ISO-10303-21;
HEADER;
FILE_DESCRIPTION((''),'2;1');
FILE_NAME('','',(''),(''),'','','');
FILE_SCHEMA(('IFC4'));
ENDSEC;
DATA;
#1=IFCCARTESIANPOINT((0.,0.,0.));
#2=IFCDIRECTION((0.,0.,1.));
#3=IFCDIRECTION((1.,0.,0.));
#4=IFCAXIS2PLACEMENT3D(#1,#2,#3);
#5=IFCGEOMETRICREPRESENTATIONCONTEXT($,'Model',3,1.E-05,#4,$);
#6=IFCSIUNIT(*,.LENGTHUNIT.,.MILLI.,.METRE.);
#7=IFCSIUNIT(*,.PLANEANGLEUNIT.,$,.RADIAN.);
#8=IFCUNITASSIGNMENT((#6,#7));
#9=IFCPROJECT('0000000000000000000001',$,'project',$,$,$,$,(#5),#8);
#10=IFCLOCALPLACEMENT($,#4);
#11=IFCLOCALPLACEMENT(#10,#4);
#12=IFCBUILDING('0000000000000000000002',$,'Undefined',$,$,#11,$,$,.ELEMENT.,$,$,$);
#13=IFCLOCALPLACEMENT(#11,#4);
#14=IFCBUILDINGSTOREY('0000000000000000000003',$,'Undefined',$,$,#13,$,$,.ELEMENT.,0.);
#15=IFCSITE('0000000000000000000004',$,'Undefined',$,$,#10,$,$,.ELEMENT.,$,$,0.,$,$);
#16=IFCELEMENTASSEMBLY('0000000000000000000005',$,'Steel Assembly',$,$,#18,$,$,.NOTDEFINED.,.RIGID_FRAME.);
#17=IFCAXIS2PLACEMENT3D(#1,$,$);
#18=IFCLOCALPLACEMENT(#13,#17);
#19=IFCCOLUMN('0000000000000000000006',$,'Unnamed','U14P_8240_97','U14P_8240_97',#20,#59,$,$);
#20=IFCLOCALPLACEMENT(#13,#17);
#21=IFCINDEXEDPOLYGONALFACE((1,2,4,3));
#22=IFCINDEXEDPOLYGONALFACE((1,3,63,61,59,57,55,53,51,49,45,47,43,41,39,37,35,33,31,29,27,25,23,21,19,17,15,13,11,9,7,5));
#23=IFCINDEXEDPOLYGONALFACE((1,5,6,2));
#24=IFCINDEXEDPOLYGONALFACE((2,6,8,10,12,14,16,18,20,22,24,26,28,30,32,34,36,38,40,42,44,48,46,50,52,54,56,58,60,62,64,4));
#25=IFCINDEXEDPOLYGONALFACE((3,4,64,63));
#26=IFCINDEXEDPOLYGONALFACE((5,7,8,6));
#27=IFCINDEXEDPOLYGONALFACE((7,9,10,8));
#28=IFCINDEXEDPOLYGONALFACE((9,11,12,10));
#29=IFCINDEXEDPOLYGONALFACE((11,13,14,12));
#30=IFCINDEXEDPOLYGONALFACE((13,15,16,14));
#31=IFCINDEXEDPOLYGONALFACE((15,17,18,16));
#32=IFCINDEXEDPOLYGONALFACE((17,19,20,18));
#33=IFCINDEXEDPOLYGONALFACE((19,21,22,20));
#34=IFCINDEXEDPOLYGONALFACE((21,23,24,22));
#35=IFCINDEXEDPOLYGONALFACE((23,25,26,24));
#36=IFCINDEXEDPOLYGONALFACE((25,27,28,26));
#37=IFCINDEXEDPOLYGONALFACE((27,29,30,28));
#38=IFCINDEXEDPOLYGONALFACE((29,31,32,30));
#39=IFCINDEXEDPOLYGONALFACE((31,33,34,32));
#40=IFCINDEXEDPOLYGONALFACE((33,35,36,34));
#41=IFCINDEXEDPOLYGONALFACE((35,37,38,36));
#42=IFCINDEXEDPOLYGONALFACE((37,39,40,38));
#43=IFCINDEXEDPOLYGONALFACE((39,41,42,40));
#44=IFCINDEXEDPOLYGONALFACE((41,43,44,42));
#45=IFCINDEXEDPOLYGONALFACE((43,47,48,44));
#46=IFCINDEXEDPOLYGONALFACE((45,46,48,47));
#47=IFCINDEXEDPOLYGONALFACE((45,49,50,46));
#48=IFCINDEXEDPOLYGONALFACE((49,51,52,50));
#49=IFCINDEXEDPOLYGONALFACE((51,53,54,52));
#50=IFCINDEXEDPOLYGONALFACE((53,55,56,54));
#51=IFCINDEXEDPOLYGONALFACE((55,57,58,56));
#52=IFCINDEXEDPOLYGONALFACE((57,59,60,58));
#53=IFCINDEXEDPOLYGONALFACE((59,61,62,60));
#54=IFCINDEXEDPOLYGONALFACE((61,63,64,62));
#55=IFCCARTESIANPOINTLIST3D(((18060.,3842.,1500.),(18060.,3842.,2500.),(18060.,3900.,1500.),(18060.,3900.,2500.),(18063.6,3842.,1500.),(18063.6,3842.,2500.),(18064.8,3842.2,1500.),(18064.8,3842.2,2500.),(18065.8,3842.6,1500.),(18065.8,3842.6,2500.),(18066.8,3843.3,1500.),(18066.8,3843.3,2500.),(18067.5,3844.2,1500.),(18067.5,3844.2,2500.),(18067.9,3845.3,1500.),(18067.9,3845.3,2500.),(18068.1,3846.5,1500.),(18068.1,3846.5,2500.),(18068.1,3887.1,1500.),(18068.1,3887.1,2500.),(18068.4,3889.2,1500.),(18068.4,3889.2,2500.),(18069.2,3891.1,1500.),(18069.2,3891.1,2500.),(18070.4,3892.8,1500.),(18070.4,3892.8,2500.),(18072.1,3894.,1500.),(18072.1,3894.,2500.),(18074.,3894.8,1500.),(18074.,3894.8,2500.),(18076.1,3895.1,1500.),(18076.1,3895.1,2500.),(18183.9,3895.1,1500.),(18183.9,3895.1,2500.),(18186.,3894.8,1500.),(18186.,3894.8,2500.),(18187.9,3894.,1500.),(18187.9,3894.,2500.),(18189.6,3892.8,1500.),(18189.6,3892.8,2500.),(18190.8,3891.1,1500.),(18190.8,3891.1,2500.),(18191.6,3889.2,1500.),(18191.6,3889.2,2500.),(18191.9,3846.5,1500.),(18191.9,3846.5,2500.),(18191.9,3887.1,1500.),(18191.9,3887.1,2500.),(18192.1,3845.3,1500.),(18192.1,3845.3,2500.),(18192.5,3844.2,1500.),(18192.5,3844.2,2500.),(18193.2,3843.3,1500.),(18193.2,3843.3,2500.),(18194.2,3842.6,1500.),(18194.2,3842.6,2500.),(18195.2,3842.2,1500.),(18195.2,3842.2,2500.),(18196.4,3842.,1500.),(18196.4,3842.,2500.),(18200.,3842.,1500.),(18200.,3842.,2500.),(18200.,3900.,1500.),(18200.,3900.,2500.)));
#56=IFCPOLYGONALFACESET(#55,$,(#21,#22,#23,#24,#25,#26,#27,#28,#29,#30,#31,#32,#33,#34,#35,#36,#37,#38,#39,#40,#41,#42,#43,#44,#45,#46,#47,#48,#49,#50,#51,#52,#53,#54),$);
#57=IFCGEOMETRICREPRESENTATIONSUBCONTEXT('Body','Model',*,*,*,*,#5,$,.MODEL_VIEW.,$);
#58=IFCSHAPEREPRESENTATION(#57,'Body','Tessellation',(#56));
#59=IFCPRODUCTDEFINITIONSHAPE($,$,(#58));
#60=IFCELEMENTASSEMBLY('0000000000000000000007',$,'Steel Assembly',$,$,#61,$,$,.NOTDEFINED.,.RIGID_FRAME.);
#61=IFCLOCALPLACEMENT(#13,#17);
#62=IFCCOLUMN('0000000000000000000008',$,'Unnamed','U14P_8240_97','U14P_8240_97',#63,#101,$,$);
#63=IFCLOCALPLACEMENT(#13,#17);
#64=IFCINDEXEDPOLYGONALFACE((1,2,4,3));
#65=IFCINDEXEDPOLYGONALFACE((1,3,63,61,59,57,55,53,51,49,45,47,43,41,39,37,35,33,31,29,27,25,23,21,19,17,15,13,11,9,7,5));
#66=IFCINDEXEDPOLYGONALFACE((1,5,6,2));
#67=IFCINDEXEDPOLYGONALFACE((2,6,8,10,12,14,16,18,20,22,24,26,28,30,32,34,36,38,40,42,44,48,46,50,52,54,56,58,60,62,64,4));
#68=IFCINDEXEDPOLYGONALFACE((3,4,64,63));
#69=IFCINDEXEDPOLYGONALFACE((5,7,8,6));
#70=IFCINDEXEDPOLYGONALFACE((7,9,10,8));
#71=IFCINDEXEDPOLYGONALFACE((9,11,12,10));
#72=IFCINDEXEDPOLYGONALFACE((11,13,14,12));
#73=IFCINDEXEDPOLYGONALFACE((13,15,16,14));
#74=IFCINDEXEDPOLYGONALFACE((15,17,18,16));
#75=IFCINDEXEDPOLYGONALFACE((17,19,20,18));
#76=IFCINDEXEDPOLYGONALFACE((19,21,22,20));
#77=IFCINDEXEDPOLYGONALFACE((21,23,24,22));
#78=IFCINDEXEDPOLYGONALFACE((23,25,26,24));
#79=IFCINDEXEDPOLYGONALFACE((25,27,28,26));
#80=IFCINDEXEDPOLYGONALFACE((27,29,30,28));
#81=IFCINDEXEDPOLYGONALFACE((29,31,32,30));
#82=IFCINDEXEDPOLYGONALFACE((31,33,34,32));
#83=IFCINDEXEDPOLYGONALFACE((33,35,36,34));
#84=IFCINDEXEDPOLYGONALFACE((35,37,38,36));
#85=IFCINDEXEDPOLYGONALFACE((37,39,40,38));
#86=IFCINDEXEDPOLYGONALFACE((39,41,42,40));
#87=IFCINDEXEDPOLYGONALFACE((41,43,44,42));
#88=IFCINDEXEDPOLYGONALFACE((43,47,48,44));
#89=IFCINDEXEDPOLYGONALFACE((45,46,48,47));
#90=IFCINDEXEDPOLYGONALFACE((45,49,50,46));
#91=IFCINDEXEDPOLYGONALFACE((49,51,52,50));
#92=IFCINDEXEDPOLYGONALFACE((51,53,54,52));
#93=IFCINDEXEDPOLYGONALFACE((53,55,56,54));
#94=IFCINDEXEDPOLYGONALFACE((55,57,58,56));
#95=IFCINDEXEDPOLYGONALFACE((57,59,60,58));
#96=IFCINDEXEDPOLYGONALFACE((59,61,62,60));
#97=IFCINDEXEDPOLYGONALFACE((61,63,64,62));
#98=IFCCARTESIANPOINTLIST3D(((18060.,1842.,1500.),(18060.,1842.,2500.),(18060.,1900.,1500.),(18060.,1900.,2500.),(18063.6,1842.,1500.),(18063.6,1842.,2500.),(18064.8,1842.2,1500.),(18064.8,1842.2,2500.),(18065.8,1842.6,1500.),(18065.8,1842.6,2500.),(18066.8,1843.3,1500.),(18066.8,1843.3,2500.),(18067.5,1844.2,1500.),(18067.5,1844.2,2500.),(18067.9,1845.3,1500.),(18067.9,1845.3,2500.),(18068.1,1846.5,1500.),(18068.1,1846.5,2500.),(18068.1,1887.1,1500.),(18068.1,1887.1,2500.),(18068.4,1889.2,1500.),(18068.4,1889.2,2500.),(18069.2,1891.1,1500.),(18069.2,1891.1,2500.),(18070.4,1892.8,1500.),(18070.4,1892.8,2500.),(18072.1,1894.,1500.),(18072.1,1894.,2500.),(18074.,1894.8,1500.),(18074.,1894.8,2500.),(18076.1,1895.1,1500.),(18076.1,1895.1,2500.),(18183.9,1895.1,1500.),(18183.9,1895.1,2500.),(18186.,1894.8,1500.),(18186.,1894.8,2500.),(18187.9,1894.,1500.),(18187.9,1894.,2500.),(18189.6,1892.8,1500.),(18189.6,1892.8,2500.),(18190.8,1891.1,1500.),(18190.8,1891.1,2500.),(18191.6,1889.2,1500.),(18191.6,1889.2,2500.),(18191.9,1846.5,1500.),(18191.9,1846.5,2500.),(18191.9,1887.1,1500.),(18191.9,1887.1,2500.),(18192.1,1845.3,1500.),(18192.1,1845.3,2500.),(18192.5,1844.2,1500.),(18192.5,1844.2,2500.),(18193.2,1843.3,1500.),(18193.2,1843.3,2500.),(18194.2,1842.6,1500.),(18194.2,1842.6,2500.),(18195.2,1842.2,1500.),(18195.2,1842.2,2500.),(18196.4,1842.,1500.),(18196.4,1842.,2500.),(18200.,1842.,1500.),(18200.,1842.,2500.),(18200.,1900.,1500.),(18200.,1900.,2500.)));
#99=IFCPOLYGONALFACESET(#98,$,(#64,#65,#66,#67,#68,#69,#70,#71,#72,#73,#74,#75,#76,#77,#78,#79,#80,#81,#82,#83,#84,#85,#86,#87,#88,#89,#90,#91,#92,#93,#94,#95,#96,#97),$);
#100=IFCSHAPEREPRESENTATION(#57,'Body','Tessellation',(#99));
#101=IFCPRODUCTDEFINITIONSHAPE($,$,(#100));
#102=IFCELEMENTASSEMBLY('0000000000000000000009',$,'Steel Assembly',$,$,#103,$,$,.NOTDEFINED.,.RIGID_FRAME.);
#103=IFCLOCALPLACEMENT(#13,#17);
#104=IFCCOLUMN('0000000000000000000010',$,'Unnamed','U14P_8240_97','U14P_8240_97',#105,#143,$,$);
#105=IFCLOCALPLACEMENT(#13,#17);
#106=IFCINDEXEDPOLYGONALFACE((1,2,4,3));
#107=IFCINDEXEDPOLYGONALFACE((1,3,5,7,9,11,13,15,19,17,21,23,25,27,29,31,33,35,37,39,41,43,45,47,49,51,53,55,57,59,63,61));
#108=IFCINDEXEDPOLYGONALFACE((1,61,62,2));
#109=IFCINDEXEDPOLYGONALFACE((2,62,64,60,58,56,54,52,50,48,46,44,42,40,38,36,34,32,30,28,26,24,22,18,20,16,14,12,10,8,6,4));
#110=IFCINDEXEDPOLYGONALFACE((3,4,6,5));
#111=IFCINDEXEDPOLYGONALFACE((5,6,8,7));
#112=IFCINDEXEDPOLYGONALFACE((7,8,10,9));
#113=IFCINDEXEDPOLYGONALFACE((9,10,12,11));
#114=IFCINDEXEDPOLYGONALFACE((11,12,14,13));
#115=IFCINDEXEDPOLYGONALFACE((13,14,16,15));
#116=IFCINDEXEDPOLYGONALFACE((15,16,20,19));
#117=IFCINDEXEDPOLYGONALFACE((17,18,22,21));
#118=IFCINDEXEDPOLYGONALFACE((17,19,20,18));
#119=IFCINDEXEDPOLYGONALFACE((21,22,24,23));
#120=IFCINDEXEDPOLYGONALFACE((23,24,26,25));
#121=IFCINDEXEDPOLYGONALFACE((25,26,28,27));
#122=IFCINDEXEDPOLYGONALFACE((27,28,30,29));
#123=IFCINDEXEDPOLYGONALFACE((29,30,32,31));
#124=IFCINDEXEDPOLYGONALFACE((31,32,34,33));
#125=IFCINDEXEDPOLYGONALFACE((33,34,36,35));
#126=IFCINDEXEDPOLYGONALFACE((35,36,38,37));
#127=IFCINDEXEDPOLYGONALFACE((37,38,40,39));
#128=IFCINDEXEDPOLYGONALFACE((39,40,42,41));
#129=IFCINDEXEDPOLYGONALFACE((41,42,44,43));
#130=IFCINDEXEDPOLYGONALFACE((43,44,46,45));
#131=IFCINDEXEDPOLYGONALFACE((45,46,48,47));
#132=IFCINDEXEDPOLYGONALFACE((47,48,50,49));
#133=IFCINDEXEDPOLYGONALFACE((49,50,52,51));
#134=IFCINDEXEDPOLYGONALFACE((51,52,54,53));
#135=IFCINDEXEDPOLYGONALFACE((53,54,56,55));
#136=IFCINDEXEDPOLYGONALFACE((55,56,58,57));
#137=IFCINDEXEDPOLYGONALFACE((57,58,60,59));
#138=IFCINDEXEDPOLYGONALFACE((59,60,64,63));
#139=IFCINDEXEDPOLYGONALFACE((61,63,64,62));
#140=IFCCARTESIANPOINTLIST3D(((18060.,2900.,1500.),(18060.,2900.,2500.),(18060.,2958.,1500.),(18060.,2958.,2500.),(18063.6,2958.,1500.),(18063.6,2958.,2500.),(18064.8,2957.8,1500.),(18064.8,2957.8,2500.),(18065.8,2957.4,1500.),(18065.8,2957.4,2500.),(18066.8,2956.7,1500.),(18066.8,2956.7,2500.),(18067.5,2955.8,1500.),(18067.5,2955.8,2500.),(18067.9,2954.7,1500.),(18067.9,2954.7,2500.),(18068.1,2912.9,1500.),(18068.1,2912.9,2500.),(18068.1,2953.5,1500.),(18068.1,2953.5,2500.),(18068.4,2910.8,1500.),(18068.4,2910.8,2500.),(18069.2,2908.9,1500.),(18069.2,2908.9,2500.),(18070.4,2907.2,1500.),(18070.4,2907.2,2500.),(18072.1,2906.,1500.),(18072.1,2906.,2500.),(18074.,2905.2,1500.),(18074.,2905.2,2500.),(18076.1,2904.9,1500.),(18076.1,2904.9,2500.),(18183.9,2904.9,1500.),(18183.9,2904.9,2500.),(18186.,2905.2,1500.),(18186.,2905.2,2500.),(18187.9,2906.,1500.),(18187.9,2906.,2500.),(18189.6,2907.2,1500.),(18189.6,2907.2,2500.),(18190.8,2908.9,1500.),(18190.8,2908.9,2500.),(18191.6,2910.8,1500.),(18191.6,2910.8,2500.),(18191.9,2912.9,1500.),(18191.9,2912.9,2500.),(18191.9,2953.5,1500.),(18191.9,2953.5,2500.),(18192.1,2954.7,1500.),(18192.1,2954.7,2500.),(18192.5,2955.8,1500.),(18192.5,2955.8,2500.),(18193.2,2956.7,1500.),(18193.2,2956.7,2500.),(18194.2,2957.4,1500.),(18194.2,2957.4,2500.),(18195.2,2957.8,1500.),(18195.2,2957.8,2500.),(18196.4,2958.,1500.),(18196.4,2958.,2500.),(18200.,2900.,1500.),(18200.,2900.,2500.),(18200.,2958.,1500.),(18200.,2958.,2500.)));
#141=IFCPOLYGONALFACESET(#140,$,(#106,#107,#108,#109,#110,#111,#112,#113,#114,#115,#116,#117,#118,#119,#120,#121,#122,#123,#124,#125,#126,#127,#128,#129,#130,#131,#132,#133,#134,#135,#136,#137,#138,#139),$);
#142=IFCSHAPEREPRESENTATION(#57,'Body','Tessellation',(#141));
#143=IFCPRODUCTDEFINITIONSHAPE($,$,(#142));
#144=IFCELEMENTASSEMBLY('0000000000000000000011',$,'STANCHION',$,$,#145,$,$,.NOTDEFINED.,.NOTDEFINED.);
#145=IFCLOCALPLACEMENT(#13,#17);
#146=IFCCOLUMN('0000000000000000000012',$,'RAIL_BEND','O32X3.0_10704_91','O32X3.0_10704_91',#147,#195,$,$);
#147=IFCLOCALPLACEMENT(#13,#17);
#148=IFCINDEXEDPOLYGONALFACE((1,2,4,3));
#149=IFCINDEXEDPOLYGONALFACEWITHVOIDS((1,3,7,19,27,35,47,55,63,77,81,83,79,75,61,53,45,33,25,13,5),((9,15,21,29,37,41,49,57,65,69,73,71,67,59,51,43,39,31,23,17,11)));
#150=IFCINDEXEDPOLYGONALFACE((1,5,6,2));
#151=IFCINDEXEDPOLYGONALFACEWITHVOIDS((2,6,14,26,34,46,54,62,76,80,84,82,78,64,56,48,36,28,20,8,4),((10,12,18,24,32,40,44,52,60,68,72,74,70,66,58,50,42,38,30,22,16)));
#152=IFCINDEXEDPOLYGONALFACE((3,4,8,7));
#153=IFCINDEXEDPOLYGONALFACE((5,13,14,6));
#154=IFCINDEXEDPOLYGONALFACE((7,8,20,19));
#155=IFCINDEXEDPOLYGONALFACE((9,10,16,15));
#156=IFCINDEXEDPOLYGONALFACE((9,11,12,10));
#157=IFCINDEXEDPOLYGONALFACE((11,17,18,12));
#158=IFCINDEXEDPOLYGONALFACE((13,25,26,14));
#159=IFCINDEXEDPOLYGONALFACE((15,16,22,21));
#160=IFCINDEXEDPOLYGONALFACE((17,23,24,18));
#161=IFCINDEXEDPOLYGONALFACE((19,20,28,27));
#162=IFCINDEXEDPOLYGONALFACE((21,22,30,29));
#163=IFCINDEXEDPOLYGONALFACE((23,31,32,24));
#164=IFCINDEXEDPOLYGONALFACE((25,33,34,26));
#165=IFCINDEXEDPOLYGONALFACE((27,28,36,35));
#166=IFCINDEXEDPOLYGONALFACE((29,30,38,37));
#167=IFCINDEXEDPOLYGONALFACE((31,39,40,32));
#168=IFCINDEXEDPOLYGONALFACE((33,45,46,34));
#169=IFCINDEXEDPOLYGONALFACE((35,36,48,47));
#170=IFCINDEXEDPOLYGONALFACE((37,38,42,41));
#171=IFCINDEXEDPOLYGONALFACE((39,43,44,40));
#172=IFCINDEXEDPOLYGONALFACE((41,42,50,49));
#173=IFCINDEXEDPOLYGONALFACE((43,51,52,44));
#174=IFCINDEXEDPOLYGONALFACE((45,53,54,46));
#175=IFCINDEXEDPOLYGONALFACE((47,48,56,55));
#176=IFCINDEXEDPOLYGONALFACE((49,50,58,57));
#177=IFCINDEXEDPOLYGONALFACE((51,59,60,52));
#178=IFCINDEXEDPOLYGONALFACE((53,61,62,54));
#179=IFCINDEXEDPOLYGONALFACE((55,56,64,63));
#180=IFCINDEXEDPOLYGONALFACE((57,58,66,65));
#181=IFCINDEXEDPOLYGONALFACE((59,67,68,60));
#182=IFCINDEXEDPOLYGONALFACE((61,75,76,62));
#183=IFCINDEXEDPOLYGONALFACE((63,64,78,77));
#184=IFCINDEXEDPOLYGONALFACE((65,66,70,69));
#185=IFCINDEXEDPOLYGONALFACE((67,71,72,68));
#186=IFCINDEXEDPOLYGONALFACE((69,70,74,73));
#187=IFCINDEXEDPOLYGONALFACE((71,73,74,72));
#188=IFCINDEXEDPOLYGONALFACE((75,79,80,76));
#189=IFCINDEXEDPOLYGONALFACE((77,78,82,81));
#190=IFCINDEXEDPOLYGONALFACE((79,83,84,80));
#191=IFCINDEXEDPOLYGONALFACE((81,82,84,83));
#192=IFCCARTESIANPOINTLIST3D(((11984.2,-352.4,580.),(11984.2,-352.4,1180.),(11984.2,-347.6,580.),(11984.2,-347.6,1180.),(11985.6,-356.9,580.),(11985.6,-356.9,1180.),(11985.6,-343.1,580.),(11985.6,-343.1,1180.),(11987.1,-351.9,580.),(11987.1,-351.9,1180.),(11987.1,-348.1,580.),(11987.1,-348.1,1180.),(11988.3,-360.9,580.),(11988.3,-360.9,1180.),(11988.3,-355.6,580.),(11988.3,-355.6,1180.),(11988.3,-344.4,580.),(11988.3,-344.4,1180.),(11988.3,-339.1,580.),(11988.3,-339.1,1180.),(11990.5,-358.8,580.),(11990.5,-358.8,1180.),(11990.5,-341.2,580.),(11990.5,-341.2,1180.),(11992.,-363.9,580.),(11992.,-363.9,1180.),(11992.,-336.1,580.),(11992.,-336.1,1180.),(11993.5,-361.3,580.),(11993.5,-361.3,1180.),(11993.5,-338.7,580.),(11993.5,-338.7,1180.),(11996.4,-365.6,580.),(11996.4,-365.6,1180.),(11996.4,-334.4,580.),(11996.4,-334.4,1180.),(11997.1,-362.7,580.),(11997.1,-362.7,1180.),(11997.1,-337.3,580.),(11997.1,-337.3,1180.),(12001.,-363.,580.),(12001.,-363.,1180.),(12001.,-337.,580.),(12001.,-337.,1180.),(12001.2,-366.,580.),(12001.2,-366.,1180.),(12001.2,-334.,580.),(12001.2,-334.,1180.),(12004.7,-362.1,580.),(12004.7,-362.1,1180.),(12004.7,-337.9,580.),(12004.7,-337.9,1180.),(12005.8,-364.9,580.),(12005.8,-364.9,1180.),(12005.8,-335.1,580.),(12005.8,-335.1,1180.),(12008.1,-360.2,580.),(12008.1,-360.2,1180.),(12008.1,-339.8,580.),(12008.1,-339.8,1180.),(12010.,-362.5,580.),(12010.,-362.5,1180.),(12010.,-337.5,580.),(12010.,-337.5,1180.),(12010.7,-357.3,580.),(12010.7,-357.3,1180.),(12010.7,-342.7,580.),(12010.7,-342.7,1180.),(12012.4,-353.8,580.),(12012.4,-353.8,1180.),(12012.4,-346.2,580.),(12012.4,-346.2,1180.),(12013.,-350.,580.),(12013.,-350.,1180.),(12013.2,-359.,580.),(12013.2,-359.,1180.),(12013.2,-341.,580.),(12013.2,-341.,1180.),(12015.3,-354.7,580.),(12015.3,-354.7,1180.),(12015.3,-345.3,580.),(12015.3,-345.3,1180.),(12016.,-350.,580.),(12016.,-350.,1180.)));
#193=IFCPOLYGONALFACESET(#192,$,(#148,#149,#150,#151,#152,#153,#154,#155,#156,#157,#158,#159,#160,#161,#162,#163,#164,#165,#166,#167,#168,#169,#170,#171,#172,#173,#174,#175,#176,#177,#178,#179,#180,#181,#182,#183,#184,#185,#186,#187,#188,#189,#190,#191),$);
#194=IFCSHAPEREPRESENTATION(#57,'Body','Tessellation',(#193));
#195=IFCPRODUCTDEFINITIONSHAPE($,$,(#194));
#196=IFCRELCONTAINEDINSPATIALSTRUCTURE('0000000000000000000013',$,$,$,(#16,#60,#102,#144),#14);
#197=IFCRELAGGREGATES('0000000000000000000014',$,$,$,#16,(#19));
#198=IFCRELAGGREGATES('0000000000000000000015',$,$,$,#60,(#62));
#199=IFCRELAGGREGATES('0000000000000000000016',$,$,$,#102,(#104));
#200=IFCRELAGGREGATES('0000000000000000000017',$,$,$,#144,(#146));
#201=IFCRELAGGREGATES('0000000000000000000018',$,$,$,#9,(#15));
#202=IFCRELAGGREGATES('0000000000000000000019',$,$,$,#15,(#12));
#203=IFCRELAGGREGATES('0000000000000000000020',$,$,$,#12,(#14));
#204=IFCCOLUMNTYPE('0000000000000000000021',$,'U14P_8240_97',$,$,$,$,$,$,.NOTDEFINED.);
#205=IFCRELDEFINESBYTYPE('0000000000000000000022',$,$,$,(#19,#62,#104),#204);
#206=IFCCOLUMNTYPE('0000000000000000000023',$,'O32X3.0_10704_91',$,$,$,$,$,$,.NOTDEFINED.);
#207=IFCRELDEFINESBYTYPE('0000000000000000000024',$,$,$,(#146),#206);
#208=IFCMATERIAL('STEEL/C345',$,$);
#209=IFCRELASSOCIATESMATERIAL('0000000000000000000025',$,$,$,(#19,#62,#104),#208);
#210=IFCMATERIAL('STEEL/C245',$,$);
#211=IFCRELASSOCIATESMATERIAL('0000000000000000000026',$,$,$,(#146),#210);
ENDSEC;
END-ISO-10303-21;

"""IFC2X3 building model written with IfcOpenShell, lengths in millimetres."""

from ifc_helpers import new_model, si_unit, frame, origin_with_axes, origin_2d_with_axis, place, context, subcontext, project, spatial, hollow_circle, u_section, extrude, material, type_object, element, aggregate, save


model = new_model("IFC2X3")

# Units and contexts
model_context = context("Model", 3, precision=1e-05, world=origin_with_axes())
body_context = subcontext(model_context, "Body", "Model", "MODEL_VIEW")
ifc_project = project(units=[si_unit("LENGTHUNIT", "METRE", prefix="MILLI"), si_unit("PLANEANGLEUNIT", "RADIAN")], contexts=[model_context])

# Site, building, storey
site_placement = place(None, origin_with_axes())
site = spatial("IfcSite", under=ifc_project, at=site_placement, Name="Undefined", CompositionType="ELEMENT", RefElevation=0.0)
building_placement = place(site_placement, origin_with_axes())
building = spatial("IfcBuilding", under=site, at=building_placement, Name="Undefined", CompositionType="ELEMENT")
storey_placement = place(building_placement, origin_with_axes())
storey = spatial("IfcBuildingStorey", under=building, at=storey_placement, Name="Undefined", CompositionType="ELEMENT", Elevation=0.0)

# Element assemblies, columns
assembly_1_placement = place(storey_placement, origin_with_axes())
assembly_1 = element("IfcElementAssembly", 1, at=assembly_1_placement, inside=storey, Name="Steel Assembly", AssemblyPlace="NOTDEFINED", PredefinedType="RIGID_FRAME")
ifc_material_1 = material(Name="STEEL/C345")
column_type_1 = type_object("IfcColumnType", Name="U14P_8240_97", PredefinedType="NOTDEFINED")
column_1_placement = place(assembly_1_placement, frame((18130.0, 3871.0, 1500.0), z_axis=(0.0, 0.0, 1.0), x_axis=(-1.0, 0.0, 0.0)))
column_1 = element("IfcColumn", 2, at=column_1_placement, type_object=column_type_1, material=ifc_material_1, Name="Unnamed", Description="U14P_8240_97", ObjectType="U14P_8240_97", context=body_context, shape_type="SweptSolid", body=[
    extrude(u_section(Depth=140.0, FlangeWidth=58.0, WebThickness=4.9, FlangeThickness=8.1, FilletRadius=8.0, EdgeRadius=4.5, at=origin_2d_with_axis()), frame((0.0, 0.0, 1000.0), z_axis=(0.0, 0.0, -1.0), x_axis=(0.0, 1.0, 0.0)), (0.0, 0.0, 1.0), 1000.0),
])
aggregate(assembly_1, [column_1])
assembly_2_placement = place(storey_placement, origin_with_axes())
assembly_2 = element("IfcElementAssembly", 3, at=assembly_2_placement, inside=storey, Name="Steel Assembly", AssemblyPlace="NOTDEFINED", PredefinedType="RIGID_FRAME")
column_2_placement = place(assembly_2_placement, frame((18130.0, 1871.0, 1500.0), z_axis=(0.0, 0.0, 1.0), x_axis=(-1.0, 0.0, 0.0)))
column_2 = element("IfcColumn", 4, at=column_2_placement, type_object=column_type_1, material=ifc_material_1, Name="Unnamed", Description="U14P_8240_97", ObjectType="U14P_8240_97", context=body_context, shape_type="SweptSolid", body=[
    extrude(u_section(Depth=140.0, FlangeWidth=58.0, WebThickness=4.9, FlangeThickness=8.1, FilletRadius=8.0, EdgeRadius=4.5, at=origin_2d_with_axis()), frame((0.0, 0.0, 1000.0), z_axis=(0.0, 0.0, -1.0), x_axis=(0.0, 1.0, 0.0)), (0.0, 0.0, 1.0), 1000.0),
])
aggregate(assembly_2, [column_2])
assembly_3_placement = place(storey_placement, origin_with_axes())
assembly_3 = element("IfcElementAssembly", 5, at=assembly_3_placement, inside=storey, Name="Steel Assembly", AssemblyPlace="NOTDEFINED", PredefinedType="RIGID_FRAME")
column_3_placement = place(assembly_3_placement, frame((18130.0, 2929.0, 1500.0), z_axis=(0.0, 0.0, 1.0), x_axis=(1.0, 0.0, 0.0)))
column_3 = element("IfcColumn", 6, at=column_3_placement, type_object=column_type_1, material=ifc_material_1, Name="Unnamed", Description="U14P_8240_97", ObjectType="U14P_8240_97", context=body_context, shape_type="SweptSolid", body=[
    extrude(u_section(Depth=140.0, FlangeWidth=58.0, WebThickness=4.9, FlangeThickness=8.1, FilletRadius=8.0, EdgeRadius=4.5, at=origin_2d_with_axis()), frame((0.0, 0.0, 1000.0), z_axis=(0.0, 0.0, -1.0), x_axis=(0.0, 1.0, 0.0)), (0.0, 0.0, 1.0), 1000.0),
])
aggregate(assembly_3, [column_3])
assembly_4_placement = place(storey_placement, origin_with_axes())
assembly_4 = element("IfcElementAssembly", 7, at=assembly_4_placement, inside=storey, Name="STANCHION", AssemblyPlace="NOTDEFINED", PredefinedType="NOTDEFINED")
ifc_material_2 = material(Name="STEEL/C245")
column_type_2 = type_object("IfcColumnType", Name="O32X3.0_10704_91", PredefinedType="NOTDEFINED")
column_4_placement = place(assembly_4_placement, frame((12000.0, -350.0, 580.0), z_axis=(0.0, 0.0, 1.0), x_axis=(0.0, -1.0, 0.0)))
column_4 = element("IfcColumn", 8, at=column_4_placement, type_object=column_type_2, material=ifc_material_2, Name="RAIL_BEND", Description="O32X3.0_10704_91", ObjectType="O32X3.0_10704_91", context=body_context, shape_type="SweptSolid", body=[
    extrude(hollow_circle(Radius=16.0, WallThickness=3.0, at=origin_2d_with_axis()), frame((0.0, 0.0, 600.0), z_axis=(0.0, 0.0, -1.0), x_axis=(0.0, 1.0, 0.0)), (0.0, 0.0, 1.0), 600.0),
])
aggregate(assembly_4, [column_4])

save(model, "model.ifc")
